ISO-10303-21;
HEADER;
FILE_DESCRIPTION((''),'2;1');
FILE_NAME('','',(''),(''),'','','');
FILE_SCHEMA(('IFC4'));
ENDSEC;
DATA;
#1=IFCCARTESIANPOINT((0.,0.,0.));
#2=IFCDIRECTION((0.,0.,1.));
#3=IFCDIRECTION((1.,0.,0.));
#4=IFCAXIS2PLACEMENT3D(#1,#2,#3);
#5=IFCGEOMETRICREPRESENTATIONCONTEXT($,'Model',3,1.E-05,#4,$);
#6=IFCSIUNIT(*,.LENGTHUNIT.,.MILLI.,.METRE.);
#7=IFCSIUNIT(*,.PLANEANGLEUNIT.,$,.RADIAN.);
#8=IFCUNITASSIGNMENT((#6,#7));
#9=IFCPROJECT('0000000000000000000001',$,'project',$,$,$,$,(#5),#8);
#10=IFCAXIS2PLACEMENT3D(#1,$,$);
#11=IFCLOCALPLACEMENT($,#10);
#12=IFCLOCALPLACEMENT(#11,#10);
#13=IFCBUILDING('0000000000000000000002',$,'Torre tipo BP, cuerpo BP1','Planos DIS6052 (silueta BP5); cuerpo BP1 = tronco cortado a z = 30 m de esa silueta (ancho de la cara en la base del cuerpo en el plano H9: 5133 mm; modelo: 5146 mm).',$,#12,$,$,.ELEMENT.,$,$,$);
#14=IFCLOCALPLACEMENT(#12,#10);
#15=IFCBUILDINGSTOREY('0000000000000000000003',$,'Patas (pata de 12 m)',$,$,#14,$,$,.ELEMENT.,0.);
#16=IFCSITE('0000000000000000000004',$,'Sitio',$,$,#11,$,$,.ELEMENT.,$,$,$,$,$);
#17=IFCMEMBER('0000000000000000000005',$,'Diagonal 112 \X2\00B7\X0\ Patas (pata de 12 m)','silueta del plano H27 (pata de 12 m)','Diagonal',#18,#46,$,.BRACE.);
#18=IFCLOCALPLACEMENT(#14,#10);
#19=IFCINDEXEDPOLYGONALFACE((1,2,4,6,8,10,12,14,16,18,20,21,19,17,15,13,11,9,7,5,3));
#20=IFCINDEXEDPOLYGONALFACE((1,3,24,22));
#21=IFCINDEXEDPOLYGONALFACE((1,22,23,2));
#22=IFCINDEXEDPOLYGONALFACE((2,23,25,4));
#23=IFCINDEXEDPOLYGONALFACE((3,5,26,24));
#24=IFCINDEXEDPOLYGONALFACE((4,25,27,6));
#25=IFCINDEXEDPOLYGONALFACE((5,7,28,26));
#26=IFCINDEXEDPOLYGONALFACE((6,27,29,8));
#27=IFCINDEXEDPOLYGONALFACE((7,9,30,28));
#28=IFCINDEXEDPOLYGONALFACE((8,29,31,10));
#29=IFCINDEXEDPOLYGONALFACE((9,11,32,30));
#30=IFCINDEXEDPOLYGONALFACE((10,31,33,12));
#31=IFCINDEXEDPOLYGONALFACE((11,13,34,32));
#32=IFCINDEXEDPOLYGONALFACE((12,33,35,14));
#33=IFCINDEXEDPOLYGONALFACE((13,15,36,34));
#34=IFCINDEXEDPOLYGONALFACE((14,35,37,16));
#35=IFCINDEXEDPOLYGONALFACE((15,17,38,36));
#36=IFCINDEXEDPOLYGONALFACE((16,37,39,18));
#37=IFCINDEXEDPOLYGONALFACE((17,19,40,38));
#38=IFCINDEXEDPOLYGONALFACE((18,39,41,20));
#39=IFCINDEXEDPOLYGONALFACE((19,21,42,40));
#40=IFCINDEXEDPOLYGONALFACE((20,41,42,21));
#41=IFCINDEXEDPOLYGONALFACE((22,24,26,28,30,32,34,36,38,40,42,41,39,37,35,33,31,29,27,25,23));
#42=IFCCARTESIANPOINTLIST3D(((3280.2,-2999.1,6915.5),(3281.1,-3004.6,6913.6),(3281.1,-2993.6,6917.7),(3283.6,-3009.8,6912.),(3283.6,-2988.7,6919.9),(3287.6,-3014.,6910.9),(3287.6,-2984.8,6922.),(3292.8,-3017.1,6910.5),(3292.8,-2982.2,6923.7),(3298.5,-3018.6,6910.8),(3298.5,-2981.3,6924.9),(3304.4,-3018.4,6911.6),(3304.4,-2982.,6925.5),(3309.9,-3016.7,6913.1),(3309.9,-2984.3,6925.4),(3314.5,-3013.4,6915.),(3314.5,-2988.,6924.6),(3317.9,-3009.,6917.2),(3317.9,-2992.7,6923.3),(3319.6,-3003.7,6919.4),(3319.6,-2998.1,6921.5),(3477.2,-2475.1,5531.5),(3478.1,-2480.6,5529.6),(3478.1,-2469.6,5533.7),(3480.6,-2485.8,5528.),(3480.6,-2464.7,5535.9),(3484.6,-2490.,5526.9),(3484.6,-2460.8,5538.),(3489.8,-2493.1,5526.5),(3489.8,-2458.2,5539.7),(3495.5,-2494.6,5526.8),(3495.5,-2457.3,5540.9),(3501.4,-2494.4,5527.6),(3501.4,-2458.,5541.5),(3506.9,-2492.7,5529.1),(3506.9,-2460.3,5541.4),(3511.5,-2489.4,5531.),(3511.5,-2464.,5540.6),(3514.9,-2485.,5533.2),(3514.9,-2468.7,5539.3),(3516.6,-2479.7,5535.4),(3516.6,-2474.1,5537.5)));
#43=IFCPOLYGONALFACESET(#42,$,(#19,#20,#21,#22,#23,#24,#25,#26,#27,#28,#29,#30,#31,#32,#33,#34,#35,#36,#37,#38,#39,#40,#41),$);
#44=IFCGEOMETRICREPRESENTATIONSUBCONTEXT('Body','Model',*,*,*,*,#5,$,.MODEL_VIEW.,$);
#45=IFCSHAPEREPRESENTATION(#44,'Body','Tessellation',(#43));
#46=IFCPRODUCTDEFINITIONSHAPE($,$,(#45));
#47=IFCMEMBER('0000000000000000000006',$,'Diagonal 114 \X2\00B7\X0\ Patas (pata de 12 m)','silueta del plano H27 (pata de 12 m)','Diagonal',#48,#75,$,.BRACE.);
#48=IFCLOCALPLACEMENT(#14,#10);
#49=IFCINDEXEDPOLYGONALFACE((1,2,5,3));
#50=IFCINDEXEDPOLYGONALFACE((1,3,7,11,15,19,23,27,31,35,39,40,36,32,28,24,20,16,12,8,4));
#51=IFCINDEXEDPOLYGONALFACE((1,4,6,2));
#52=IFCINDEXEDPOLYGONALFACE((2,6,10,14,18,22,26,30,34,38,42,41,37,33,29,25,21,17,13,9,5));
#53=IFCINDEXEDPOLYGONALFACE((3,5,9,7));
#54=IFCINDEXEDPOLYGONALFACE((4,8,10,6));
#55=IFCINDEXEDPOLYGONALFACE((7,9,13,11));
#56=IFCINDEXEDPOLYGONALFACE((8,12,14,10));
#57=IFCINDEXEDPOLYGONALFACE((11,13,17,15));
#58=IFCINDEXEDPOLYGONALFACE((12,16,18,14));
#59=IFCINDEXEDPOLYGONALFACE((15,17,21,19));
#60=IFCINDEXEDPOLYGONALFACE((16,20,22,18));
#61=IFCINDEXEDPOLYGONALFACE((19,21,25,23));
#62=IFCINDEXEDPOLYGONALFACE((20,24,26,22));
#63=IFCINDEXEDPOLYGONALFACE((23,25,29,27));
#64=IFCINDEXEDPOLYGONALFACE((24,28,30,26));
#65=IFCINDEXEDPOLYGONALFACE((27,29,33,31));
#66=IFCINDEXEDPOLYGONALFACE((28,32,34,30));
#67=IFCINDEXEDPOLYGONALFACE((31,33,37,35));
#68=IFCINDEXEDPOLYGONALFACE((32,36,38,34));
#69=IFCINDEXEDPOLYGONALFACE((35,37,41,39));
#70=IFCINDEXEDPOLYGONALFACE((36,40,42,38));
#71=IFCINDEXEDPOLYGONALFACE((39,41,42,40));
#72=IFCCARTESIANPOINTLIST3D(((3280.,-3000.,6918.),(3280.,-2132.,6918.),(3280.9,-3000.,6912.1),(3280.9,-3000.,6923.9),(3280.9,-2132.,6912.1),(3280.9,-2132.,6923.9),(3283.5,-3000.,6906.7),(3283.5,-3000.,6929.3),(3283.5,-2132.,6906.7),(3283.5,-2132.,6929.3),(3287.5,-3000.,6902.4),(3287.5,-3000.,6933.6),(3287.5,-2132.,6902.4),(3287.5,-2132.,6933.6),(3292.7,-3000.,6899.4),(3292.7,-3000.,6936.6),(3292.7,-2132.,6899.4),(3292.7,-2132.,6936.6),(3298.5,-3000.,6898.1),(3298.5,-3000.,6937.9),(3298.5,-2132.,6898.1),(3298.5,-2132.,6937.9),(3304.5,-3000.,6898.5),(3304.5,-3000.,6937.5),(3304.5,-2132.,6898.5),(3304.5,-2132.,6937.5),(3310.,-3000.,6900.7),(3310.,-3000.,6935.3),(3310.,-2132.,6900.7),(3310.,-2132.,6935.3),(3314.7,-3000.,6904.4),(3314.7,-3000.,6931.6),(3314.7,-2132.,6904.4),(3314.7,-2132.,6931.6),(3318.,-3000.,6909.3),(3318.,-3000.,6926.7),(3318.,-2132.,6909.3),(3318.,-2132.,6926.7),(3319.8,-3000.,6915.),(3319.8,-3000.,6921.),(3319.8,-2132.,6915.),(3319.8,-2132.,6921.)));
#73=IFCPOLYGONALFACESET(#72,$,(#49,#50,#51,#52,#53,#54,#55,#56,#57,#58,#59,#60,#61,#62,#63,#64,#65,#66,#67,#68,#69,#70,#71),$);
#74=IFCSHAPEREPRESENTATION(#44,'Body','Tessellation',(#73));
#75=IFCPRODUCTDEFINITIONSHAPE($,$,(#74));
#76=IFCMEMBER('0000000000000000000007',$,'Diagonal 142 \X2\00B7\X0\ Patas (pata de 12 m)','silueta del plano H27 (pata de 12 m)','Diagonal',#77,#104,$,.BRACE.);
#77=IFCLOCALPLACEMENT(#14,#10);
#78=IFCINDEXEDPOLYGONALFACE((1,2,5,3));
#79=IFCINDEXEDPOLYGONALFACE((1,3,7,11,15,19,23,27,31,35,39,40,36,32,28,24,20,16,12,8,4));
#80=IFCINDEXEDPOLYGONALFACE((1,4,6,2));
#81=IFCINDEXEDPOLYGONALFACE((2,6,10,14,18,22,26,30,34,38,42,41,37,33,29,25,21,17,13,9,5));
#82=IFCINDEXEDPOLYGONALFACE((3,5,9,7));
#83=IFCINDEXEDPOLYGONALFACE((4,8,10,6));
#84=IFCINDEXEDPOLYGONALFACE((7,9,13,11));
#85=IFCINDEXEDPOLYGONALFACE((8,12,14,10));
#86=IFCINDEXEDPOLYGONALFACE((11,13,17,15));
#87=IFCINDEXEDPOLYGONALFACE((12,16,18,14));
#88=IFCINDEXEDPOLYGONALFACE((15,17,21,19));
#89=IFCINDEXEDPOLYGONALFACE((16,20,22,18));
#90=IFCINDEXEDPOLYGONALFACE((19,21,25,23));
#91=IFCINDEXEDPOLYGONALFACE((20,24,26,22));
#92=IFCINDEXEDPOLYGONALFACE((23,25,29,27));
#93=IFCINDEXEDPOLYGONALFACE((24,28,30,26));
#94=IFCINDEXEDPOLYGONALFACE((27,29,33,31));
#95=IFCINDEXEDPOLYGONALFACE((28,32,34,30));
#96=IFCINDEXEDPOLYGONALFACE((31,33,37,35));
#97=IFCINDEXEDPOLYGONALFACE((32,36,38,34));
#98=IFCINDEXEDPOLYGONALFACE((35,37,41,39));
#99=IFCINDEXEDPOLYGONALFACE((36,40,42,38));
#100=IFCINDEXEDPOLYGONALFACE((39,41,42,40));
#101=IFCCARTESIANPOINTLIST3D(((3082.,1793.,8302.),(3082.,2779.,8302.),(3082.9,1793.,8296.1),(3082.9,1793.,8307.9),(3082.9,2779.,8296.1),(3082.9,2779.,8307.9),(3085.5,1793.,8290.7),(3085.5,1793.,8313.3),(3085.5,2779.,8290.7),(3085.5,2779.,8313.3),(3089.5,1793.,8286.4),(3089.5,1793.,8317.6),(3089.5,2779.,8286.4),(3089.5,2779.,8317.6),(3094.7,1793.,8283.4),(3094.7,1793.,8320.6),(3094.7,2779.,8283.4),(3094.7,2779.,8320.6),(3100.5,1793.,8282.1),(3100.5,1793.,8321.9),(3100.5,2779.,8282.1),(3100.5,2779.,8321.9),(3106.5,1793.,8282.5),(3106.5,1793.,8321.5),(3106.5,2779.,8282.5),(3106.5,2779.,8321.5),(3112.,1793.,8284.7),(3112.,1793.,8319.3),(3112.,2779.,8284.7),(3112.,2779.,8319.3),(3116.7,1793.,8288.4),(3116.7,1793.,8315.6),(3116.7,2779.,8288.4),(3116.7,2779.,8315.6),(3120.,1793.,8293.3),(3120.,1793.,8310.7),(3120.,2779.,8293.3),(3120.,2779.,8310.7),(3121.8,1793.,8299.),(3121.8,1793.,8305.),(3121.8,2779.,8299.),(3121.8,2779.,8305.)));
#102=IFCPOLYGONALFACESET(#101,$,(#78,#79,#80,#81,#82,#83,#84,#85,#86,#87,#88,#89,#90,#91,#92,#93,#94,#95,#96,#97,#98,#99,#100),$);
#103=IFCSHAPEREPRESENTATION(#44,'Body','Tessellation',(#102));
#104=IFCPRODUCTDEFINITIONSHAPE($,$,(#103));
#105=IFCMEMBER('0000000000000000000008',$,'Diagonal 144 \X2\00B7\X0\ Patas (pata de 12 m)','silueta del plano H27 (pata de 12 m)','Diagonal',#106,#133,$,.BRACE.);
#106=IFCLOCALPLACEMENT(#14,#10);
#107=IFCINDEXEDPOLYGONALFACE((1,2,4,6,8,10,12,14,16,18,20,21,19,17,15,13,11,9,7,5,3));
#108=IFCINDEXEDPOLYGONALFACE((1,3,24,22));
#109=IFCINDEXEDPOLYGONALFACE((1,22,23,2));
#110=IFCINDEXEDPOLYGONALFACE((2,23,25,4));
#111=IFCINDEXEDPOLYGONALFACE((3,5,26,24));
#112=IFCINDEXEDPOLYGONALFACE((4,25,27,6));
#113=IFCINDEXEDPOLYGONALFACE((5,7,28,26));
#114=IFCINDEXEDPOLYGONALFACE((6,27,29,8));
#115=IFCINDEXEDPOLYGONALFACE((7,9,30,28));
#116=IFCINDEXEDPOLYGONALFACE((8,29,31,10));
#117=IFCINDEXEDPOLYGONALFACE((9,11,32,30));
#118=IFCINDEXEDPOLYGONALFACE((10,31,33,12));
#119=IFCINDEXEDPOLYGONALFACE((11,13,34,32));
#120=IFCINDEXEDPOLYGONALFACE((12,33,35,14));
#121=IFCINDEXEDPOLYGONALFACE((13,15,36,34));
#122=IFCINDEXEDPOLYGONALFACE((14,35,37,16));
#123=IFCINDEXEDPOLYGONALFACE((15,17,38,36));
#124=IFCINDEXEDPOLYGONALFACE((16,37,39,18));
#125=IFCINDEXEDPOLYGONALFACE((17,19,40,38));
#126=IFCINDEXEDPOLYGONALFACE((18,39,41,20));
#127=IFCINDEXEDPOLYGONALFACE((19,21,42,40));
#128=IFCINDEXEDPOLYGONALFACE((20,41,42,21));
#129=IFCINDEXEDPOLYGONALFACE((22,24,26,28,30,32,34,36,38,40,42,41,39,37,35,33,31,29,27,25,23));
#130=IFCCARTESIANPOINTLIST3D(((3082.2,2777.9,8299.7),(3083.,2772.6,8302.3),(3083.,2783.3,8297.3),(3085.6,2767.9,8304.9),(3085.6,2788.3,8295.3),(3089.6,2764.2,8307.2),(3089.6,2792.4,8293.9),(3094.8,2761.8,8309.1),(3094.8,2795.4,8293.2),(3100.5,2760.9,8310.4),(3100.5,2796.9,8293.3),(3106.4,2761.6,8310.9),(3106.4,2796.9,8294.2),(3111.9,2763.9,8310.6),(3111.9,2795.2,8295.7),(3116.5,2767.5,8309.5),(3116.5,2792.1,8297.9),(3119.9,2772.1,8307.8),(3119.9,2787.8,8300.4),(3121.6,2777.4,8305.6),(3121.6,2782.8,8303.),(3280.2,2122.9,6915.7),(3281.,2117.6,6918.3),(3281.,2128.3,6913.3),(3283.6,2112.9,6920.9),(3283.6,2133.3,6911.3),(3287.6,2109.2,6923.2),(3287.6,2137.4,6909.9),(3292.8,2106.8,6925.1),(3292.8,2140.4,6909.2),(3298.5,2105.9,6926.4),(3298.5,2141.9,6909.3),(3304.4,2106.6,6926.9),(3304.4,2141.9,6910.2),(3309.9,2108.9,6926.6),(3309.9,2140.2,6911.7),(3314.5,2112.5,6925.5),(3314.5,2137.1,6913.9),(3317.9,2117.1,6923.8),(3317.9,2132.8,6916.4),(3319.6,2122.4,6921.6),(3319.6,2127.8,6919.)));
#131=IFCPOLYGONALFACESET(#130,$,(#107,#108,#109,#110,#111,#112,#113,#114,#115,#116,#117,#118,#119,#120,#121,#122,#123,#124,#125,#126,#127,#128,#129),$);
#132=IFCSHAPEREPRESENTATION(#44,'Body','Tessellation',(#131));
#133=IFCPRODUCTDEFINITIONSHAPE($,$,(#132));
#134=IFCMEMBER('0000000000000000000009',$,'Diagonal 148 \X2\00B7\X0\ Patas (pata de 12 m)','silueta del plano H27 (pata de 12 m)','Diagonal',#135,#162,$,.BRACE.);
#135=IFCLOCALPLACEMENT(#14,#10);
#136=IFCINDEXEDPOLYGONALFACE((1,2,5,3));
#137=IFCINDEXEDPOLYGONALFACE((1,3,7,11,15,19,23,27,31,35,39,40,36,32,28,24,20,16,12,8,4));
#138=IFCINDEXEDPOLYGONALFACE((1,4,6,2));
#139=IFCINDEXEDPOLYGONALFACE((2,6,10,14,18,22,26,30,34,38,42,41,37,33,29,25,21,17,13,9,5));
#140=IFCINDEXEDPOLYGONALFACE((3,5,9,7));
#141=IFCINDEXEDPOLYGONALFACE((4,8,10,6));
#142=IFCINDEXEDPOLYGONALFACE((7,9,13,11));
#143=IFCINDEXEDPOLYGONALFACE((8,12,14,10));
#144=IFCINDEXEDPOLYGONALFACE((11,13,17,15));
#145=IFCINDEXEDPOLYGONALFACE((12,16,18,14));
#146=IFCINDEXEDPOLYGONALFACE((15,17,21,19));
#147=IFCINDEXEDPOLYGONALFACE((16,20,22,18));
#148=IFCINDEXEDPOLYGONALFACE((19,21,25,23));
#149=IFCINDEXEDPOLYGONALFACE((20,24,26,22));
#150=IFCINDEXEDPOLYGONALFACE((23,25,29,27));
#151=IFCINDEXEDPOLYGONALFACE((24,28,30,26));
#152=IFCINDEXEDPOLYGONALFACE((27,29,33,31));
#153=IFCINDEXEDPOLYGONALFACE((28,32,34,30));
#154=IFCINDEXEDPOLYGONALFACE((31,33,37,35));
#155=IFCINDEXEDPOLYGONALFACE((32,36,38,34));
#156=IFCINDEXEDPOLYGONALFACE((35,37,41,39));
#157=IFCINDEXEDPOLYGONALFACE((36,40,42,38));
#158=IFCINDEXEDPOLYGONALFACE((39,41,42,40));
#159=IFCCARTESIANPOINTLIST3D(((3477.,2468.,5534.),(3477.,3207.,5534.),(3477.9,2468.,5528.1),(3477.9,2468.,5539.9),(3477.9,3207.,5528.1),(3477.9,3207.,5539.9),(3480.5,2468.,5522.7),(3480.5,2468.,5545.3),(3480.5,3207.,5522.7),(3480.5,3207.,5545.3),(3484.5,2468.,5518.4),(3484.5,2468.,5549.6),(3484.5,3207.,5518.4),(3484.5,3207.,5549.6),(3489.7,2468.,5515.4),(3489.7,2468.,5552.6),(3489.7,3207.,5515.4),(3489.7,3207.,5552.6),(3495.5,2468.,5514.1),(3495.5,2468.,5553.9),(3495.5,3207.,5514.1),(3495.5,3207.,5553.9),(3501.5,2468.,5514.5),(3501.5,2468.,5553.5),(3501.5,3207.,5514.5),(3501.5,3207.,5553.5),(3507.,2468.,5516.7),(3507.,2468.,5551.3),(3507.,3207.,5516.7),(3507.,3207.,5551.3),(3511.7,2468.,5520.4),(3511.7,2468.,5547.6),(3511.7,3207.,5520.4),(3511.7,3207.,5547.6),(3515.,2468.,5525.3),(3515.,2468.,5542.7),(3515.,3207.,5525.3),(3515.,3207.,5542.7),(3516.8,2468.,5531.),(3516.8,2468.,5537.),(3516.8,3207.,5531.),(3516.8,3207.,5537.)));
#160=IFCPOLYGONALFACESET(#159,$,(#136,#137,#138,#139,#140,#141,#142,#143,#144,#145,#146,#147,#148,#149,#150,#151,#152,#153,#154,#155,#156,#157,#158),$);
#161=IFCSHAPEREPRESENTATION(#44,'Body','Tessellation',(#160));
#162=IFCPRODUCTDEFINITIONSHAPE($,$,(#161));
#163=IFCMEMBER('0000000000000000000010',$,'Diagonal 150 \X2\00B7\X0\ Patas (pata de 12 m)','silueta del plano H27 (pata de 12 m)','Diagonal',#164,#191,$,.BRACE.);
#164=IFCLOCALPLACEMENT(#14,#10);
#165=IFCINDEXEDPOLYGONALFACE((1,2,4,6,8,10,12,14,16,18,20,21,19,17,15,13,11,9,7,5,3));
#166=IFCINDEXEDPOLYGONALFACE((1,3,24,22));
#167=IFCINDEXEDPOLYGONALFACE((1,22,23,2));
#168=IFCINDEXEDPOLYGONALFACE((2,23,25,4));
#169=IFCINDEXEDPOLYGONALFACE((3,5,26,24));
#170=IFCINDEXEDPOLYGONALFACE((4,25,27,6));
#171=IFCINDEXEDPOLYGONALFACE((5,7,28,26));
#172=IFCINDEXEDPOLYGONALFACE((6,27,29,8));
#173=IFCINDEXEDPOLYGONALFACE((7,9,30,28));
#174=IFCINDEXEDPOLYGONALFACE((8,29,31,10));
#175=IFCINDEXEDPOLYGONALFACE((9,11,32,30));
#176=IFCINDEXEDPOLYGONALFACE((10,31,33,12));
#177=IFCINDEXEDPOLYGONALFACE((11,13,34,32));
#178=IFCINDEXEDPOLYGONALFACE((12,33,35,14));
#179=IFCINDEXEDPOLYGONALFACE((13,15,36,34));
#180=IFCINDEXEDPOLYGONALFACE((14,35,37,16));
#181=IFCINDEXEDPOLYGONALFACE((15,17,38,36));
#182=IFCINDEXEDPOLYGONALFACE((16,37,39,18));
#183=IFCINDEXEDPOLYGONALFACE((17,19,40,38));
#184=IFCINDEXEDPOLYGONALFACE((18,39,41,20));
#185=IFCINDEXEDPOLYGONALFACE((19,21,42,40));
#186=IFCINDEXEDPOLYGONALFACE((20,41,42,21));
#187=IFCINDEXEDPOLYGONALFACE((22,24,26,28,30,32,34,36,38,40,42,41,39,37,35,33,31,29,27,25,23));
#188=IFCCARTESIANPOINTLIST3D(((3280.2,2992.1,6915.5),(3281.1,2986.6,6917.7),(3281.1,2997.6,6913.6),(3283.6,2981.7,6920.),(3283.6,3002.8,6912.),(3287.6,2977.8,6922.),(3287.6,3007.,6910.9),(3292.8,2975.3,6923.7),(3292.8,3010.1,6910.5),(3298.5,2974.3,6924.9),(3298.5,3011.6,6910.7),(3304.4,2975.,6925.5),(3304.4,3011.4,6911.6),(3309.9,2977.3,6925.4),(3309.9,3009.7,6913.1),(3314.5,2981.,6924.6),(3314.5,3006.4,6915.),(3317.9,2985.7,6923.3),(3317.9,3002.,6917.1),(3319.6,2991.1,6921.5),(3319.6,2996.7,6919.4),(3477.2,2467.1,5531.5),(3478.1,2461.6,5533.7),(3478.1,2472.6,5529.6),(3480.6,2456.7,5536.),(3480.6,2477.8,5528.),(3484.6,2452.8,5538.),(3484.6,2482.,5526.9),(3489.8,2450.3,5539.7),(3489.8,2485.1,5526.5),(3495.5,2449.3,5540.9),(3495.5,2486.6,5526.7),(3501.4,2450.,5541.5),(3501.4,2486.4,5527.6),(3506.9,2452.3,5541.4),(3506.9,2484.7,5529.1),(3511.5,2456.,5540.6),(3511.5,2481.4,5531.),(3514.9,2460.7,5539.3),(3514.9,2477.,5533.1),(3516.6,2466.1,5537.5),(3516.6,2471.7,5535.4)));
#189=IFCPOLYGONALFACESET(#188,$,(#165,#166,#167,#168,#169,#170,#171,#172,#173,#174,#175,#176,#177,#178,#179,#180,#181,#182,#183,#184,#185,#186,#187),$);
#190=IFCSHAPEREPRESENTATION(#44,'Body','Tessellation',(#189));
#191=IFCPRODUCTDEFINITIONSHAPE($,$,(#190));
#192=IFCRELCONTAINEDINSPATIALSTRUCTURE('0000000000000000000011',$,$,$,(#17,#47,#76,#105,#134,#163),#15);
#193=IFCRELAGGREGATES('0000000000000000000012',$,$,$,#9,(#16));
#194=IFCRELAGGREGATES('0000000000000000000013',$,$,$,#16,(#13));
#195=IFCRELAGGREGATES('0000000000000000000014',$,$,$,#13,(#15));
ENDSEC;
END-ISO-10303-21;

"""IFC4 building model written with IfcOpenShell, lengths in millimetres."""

from ifc_helpers import new_model, si_unit, frame, origin, origin_with_axes, place, context, subcontext, project, spatial, circle, extrude, element, save


model = new_model("IFC4")

# Units and contexts
model_context = context("Model", 3, precision=1e-05, world=origin_with_axes())
body_context = subcontext(model_context, "Body", "Model", "MODEL_VIEW")
ifc_project = project(units=[si_unit("LENGTHUNIT", "METRE", prefix="MILLI"), si_unit("PLANEANGLEUNIT", "RADIAN")], contexts=[model_context])

# Site, building, storey
site_placement = place(None, origin())
site = spatial("IfcSite", under=ifc_project, at=site_placement, Name="Sitio", CompositionType="ELEMENT")
building_placement = place(site_placement, origin())
building = spatial("IfcBuilding", under=site, at=building_placement, Name="Torre tipo BP, cuerpo BP1", Description="Planos DIS6052 (silueta BP5); cuerpo BP1 = tronco cortado a z = 30 m de esa silueta (ancho de la cara en la base del cuerpo en el plano H9: 5133 mm; modelo: 5146 mm).", CompositionType="ELEMENT")
storey_placement = place(building_placement, origin())
storey = spatial("IfcBuildingStorey", under=building, at=storey_placement, Name="Patas (pata de 12 m)", CompositionType="ELEMENT", Elevation=0.0)

# Members
member_1_placement = place(storey_placement, frame((3497.0, -2476.0, 5534.0), z_axis=(-0.131955, -0.350988, 0.927036), x_axis=(-0.991256, 0.046723, -0.123406)))
element("IfcMember", 1, at=member_1_placement, inside=storey, Name="Diagonal 112 · Patas (pata de 12 m)", Description="silueta del plano H27 (pata de 12 m)", ObjectType="Diagonal", PredefinedType="BRACE", context=body_context, shape_type="SweptSolid", body=[
    extrude(circle(Radius=20.0), None, (0.0, 0.0, 1.0), 1492.9),
])
member_2_placement = place(storey_placement, frame((3300.0, -3000.0, 6918.0), z_axis=(0.0, 1.0, 0.0), x_axis=(-1.0, 0.0, 0.0)))
element("IfcMember", 2, at=member_2_placement, inside=storey, Name="Diagonal 114 · Patas (pata de 12 m)", Description="silueta del plano H27 (pata de 12 m)", ObjectType="Diagonal", PredefinedType="BRACE", context=body_context, shape_type="SweptSolid", body=[
    extrude(circle(Radius=20.0), None, (0.0, 0.0, 1.0), 868.0),
])
member_3_placement = place(storey_placement, frame((3102.0, 2779.0, 8302.0), z_axis=(0.0, -1.0, 0.0), x_axis=(-1.0, 0.0, 0.0)))
element("IfcMember", 3, at=member_3_placement, inside=storey, Name="Diagonal 142 · Patas (pata de 12 m)", Description="silueta del plano H27 (pata de 12 m)", ObjectType="Diagonal", PredefinedType="BRACE", context=body_context, shape_type="SweptSolid", body=[
    extrude(circle(Radius=20.0), None, (0.0, 0.0, 1.0), 986.0),
])
member_4_placement = place(storey_placement, frame((3300.0, 2124.0, 6918.0), z_axis=(-0.128245, 0.424245, 0.89642), x_axis=(-0.991743, -0.05486, -0.115919)))
element("IfcMember", 4, at=member_4_placement, inside=storey, Name="Diagonal 144 · Patas (pata de 12 m)", Description="silueta del plano H27 (pata de 12 m)", ObjectType="Diagonal", PredefinedType="BRACE", context=body_context, shape_type="SweptSolid", body=[
    extrude(circle(Radius=20.0), None, (0.0, 0.0, 1.0), 1543.9),
])
member_5_placement = place(storey_placement, frame((3497.0, 3207.0, 5534.0), z_axis=(0.0, -1.0, 0.0), x_axis=(-1.0, 0.0, 0.0)))
element("IfcMember", 5, at=member_5_placement, inside=storey, Name="Diagonal 148 · Patas (pata de 12 m)", Description="silueta del plano H27 (pata de 12 m)", ObjectType="Diagonal", PredefinedType="BRACE", context=body_context, shape_type="SweptSolid", body=[
    extrude(circle(Radius=20.0), None, (0.0, 0.0, 1.0), 739.0),
])
member_6_placement = place(storey_placement, frame((3497.0, 2468.0, 5534.0), z_axis=(-0.131924, 0.351575, 0.926818), x_axis=(-0.99126, -0.04679, -0.123348)))
element("IfcMember", 6, at=member_6_placement, inside=storey, Name="Diagonal 150 · Patas (pata de 12 m)", Description="silueta del plano H27 (pata de 12 m)", ObjectType="Diagonal", PredefinedType="BRACE", context=body_context, shape_type="SweptSolid", body=[
    extrude(circle(Radius=20.0), None, (0.0, 0.0, 1.0), 1493.3),
])

save(model, "model.ifc")
